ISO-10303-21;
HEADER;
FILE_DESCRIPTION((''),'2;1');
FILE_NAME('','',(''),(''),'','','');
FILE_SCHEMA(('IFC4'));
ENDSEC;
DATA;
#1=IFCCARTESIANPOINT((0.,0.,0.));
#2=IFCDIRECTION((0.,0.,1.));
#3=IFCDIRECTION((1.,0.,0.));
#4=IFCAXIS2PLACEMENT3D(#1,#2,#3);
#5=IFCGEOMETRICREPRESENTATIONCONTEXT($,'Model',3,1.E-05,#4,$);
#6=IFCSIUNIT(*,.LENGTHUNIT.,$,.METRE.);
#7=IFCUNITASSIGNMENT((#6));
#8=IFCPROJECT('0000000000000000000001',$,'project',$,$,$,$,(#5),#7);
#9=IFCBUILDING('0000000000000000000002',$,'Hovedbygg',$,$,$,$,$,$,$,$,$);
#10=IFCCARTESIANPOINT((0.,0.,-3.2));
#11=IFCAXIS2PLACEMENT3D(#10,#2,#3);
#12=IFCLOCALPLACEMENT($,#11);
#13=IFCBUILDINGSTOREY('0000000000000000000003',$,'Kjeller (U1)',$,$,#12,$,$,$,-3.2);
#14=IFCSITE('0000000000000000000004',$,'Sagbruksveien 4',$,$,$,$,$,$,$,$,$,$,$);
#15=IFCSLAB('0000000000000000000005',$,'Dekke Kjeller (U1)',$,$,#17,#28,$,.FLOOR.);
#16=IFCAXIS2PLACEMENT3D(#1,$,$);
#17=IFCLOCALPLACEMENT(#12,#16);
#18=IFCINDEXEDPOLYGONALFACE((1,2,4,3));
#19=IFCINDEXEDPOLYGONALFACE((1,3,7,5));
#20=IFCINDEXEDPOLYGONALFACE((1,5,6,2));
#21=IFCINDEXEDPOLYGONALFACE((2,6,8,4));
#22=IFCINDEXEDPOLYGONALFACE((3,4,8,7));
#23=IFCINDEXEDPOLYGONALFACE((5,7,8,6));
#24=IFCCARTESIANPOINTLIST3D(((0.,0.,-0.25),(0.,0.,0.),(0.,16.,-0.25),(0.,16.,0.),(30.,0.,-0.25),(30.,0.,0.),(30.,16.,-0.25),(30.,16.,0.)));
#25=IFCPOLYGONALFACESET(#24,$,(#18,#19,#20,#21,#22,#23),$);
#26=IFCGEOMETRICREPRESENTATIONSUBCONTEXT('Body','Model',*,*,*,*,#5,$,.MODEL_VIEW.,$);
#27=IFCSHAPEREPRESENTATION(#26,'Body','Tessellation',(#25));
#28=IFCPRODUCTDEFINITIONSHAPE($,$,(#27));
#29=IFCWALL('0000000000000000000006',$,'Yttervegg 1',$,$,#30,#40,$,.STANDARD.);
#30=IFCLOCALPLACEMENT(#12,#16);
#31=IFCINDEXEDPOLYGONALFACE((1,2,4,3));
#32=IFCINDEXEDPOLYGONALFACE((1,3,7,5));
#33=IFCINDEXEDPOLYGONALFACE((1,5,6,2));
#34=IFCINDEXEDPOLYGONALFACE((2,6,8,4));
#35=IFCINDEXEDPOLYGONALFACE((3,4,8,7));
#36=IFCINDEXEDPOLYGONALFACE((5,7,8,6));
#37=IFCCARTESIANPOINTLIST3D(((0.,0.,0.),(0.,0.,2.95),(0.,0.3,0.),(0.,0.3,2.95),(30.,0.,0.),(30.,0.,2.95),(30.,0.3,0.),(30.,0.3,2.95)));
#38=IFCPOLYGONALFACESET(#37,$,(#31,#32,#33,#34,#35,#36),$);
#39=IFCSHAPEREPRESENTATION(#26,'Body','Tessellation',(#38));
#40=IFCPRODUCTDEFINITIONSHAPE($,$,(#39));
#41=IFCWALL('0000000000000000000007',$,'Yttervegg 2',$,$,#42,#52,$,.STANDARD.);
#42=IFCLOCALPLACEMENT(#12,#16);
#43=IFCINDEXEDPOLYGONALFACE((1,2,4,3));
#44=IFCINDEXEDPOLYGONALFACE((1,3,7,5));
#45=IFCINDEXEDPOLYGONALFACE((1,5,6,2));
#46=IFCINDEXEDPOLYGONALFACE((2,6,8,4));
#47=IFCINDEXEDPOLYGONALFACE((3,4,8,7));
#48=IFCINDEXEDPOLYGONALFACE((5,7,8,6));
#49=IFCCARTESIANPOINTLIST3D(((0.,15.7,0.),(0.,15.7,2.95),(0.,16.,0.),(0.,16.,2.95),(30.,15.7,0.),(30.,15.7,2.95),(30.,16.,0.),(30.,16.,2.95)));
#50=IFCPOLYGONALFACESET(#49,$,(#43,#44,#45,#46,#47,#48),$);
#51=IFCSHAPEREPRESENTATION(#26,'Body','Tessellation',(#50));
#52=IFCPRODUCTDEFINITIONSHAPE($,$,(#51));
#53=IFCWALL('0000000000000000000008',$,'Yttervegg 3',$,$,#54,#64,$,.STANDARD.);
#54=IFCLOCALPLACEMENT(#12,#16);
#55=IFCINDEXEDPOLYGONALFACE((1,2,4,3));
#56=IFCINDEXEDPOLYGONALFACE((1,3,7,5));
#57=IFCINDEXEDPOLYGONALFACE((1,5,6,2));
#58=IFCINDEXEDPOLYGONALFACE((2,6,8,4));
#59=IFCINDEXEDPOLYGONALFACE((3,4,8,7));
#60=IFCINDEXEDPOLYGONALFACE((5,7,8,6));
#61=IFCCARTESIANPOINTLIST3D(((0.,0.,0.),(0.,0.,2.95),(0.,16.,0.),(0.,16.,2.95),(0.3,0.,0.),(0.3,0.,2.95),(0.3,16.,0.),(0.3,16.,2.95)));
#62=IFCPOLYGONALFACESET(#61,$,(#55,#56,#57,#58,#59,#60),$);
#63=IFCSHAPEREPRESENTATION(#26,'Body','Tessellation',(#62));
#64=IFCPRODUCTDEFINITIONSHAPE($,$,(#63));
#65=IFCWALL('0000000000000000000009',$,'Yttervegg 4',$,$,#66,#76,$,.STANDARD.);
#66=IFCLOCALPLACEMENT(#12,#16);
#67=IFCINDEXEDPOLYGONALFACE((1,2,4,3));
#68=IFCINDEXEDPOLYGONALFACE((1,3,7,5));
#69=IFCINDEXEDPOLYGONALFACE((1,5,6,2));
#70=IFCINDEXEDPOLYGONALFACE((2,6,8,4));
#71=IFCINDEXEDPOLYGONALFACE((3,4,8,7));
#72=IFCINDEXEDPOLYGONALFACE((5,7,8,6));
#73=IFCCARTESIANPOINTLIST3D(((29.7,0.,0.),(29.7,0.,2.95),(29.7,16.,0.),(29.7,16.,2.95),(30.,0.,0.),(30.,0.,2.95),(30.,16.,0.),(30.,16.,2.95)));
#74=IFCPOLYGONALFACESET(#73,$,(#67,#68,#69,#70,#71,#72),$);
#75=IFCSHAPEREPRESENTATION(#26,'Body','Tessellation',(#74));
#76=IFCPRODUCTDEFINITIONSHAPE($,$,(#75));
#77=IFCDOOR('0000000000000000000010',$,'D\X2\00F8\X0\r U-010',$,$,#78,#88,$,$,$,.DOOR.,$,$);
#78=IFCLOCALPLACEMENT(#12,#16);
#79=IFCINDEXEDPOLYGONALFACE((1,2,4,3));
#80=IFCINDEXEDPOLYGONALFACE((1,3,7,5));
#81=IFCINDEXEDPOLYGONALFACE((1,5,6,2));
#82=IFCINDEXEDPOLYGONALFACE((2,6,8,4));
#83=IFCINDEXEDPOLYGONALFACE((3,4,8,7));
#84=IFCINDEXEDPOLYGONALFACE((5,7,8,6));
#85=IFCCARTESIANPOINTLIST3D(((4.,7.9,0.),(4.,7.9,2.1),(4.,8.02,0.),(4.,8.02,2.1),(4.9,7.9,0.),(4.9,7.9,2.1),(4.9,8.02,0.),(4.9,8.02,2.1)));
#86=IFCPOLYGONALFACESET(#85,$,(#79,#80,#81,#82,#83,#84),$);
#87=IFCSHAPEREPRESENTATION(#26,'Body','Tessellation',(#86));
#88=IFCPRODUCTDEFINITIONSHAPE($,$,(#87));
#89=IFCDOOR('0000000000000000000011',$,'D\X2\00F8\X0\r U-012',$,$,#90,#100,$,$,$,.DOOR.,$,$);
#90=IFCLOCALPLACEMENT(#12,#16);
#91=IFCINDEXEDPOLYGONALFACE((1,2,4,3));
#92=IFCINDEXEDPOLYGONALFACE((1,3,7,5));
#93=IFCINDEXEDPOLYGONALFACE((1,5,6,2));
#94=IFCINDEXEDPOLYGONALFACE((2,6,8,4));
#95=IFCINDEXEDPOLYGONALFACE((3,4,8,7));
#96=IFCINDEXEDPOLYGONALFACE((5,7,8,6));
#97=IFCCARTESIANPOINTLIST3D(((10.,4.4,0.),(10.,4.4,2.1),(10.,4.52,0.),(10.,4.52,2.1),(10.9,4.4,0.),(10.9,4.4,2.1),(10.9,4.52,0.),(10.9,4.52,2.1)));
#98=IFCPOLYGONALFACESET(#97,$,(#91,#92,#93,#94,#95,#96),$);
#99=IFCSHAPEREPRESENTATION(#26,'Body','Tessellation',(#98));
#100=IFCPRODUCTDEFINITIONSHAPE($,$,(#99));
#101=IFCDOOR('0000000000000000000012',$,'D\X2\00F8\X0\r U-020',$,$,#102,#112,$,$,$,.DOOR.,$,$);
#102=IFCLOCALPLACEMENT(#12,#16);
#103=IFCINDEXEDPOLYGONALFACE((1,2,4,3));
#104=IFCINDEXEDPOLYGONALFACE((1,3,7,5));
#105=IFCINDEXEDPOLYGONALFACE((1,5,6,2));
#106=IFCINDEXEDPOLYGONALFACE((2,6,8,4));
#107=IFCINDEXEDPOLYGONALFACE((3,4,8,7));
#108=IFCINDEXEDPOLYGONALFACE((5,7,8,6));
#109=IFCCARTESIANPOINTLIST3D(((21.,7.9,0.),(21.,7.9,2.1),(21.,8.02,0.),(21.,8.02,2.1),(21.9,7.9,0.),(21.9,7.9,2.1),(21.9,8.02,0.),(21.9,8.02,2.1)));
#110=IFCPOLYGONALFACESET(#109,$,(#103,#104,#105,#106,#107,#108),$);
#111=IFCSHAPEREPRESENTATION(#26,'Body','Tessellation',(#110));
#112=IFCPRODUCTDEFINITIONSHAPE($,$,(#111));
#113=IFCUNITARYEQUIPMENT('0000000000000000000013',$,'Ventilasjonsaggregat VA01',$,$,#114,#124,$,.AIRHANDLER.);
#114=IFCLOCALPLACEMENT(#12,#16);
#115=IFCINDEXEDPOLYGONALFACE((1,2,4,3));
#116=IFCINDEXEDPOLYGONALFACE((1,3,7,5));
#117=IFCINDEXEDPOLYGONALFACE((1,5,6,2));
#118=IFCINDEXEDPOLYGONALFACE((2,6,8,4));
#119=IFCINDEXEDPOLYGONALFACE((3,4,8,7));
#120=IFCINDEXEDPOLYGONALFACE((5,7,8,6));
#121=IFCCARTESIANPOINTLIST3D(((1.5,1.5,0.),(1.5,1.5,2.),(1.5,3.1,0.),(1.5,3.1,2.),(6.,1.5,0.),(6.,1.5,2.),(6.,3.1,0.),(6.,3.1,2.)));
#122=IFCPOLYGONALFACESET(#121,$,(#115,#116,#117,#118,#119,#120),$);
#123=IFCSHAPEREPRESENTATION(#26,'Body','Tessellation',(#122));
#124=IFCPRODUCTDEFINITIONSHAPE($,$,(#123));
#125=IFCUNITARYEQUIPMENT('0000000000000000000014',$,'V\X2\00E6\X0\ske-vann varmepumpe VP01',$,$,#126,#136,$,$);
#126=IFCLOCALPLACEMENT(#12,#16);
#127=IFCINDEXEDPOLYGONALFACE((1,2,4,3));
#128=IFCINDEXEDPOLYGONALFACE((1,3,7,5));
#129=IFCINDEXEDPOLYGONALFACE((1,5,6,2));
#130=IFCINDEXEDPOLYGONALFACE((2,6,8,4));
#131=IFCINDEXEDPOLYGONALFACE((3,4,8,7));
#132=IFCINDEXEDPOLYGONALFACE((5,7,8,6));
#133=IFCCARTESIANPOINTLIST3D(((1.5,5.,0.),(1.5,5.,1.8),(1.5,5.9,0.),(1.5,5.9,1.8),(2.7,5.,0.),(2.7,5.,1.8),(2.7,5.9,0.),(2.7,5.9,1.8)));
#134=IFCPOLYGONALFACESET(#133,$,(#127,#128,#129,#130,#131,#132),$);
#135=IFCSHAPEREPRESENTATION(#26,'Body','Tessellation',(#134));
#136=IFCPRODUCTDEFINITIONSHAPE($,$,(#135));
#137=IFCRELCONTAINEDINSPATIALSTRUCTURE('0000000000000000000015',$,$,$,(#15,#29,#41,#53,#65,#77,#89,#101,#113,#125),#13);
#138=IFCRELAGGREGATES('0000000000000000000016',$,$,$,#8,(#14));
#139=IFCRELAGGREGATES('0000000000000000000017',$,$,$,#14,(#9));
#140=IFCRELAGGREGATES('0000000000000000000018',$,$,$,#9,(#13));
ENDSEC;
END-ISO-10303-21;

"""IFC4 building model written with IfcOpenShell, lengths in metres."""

from ifc_helpers import new_model, si_unit, frame, origin_with_axes, place, context, subcontext, project, spatial, line, indexed_curve, outline, extrude, element, save


model = new_model("IFC4")

# Units and contexts
model_context = context("Model", 3, precision=1e-05, world=origin_with_axes())
body_context = subcontext(model_context, "Body", "Model", "MODEL_VIEW")
ifc_project = project(units=[si_unit("LENGTHUNIT", "METRE")], contexts=[model_context])

# Site, building, storey
site = spatial("IfcSite", under=ifc_project, Name="Sagbruksveien 4")
building = spatial("IfcBuilding", under=site, Name="Hovedbygg")
storey_placement = place(None, frame((0.0, 0.0, -3.2), z_axis=(0.0, 0.0, 1.0), x_axis=(1.0, 0.0, 0.0)))
storey = spatial("IfcBuildingStorey", under=building, at=storey_placement, Name="Kjeller (U1)", Elevation=-3.2)

# Slab
slab_placement = place(storey_placement, frame((0.0, 0.0, -0.25), z_axis=(0.0, 0.0, 1.0), x_axis=(1.0, 0.0, 0.0)))
element("IfcSlab", 1, at=slab_placement, inside=storey, Name="Dekke Kjeller (U1)", PredefinedType="FLOOR", context=body_context, shape_type="SweptSolid", body=[
    extrude(outline(indexed_curve([(0.0, 0.0), (30.0, 0.0), (30.0, 16.0), (0.0, 16.0)], segments=[line(1, 2, 3, 4, 1)])), origin_with_axes(), (0.0, 0.0, 1.0), 0.25),
])

# Walls
for number, where, z_axis, x_axis, name in (
    (2, (0.0, 0.0, 0.0), (0.0, 0.0, 1.0), (1.0, 0.0, 0.0), "Yttervegg 1"),
    (3, (0.0, 15.7, 0.0), (0.0, 0.0, 1.0), (1.0, 0.0, 0.0), "Yttervegg 2"),
):
    element("IfcWall", number, at=place(storey_placement, frame(where, z_axis=z_axis, x_axis=x_axis)), inside=storey, Name=name, PredefinedType="STANDARD", context=body_context, shape_type="SweptSolid", body=[
        extrude(outline(indexed_curve([(0.0, 0.0), (30.0, 0.0), (30.0, 0.3), (0.0, 0.3)], segments=[line(1, 2, 3, 4, 1)])), origin_with_axes(), (0.0, 0.0, 1.0), 2.95),
    ])
for number, where, z_axis, x_axis, name in (
    (4, (0.0, 0.0, 0.0), (0.0, 0.0, 1.0), (1.0, 0.0, 0.0), "Yttervegg 3"),
    (5, (29.7, 0.0, 0.0), (0.0, 0.0, 1.0), (1.0, 0.0, 0.0), "Yttervegg 4"),
):
    element("IfcWall", number, at=place(storey_placement, frame(where, z_axis=z_axis, x_axis=x_axis)), inside=storey, Name=name, PredefinedType="STANDARD", context=body_context, shape_type="SweptSolid", body=[
        extrude(outline(indexed_curve([(0.0, 0.0), (0.3, 0.0), (0.3, 16.0), (0.0, 16.0)], segments=[line(1, 2, 3, 4, 1)])), origin_with_axes(), (0.0, 0.0, 1.0), 2.95),
    ])

# Doors
for number, where, z_axis, x_axis, name in (
    (6, (4.0, 7.9, 0.0), (0.0, 0.0, 1.0), (1.0, 0.0, 0.0), "Dør U-010"),
    (7, (10.0, 4.4, 0.0), (0.0, 0.0, 1.0), (1.0, 0.0, 0.0), "Dør U-012"),
    (8, (21.0, 7.9, 0.0), (0.0, 0.0, 1.0), (1.0, 0.0, 0.0), "Dør U-020"),
):
    element("IfcDoor", number, at=place(storey_placement, frame(where, z_axis=z_axis, x_axis=x_axis)), inside=storey, Name=name, PredefinedType="DOOR", context=body_context, shape_type="SweptSolid", body=[
        extrude(outline(indexed_curve([(0.0, 0.0), (0.9, 0.0), (0.9, 0.12), (0.0, 0.12)], segments=[line(1, 2, 3, 4, 1)])), origin_with_axes(), (0.0, 0.0, 1.0), 2.1),
    ])

# Unitary equipment
unitary_equipment_1_placement = place(storey_placement, frame((1.5, 1.5, 0.0), z_axis=(0.0, 0.0, 1.0), x_axis=(1.0, 0.0, 0.0)))
element("IfcUnitaryEquipment", 9, at=unitary_equipment_1_placement, inside=storey, Name="Ventilasjonsaggregat VA01", PredefinedType="AIRHANDLER", context=body_context, shape_type="SweptSolid", body=[
    extrude(outline(indexed_curve([(0.0, 0.0), (4.5, 0.0), (4.5, 1.6), (0.0, 1.6)], segments=[line(1, 2, 3, 4, 1)])), origin_with_axes(), (0.0, 0.0, 1.0), 2.0),
])
unitary_equipment_2_placement = place(storey_placement, frame((1.5, 5.0, 0.0), z_axis=(0.0, 0.0, 1.0), x_axis=(1.0, 0.0, 0.0)))
element("IfcUnitaryEquipment", 10, at=unitary_equipment_2_placement, inside=storey, Name="Væske-vann varmepumpe VP01", context=body_context, shape_type="SweptSolid", body=[
    extrude(outline(indexed_curve([(0.0, 0.0), (1.2, 0.0), (1.2, 0.9), (0.0, 0.9)], segments=[line(1, 2, 3, 4, 1)])), origin_with_axes(), (0.0, 0.0, 1.0), 1.8),
])

save(model, "model.ifc")
